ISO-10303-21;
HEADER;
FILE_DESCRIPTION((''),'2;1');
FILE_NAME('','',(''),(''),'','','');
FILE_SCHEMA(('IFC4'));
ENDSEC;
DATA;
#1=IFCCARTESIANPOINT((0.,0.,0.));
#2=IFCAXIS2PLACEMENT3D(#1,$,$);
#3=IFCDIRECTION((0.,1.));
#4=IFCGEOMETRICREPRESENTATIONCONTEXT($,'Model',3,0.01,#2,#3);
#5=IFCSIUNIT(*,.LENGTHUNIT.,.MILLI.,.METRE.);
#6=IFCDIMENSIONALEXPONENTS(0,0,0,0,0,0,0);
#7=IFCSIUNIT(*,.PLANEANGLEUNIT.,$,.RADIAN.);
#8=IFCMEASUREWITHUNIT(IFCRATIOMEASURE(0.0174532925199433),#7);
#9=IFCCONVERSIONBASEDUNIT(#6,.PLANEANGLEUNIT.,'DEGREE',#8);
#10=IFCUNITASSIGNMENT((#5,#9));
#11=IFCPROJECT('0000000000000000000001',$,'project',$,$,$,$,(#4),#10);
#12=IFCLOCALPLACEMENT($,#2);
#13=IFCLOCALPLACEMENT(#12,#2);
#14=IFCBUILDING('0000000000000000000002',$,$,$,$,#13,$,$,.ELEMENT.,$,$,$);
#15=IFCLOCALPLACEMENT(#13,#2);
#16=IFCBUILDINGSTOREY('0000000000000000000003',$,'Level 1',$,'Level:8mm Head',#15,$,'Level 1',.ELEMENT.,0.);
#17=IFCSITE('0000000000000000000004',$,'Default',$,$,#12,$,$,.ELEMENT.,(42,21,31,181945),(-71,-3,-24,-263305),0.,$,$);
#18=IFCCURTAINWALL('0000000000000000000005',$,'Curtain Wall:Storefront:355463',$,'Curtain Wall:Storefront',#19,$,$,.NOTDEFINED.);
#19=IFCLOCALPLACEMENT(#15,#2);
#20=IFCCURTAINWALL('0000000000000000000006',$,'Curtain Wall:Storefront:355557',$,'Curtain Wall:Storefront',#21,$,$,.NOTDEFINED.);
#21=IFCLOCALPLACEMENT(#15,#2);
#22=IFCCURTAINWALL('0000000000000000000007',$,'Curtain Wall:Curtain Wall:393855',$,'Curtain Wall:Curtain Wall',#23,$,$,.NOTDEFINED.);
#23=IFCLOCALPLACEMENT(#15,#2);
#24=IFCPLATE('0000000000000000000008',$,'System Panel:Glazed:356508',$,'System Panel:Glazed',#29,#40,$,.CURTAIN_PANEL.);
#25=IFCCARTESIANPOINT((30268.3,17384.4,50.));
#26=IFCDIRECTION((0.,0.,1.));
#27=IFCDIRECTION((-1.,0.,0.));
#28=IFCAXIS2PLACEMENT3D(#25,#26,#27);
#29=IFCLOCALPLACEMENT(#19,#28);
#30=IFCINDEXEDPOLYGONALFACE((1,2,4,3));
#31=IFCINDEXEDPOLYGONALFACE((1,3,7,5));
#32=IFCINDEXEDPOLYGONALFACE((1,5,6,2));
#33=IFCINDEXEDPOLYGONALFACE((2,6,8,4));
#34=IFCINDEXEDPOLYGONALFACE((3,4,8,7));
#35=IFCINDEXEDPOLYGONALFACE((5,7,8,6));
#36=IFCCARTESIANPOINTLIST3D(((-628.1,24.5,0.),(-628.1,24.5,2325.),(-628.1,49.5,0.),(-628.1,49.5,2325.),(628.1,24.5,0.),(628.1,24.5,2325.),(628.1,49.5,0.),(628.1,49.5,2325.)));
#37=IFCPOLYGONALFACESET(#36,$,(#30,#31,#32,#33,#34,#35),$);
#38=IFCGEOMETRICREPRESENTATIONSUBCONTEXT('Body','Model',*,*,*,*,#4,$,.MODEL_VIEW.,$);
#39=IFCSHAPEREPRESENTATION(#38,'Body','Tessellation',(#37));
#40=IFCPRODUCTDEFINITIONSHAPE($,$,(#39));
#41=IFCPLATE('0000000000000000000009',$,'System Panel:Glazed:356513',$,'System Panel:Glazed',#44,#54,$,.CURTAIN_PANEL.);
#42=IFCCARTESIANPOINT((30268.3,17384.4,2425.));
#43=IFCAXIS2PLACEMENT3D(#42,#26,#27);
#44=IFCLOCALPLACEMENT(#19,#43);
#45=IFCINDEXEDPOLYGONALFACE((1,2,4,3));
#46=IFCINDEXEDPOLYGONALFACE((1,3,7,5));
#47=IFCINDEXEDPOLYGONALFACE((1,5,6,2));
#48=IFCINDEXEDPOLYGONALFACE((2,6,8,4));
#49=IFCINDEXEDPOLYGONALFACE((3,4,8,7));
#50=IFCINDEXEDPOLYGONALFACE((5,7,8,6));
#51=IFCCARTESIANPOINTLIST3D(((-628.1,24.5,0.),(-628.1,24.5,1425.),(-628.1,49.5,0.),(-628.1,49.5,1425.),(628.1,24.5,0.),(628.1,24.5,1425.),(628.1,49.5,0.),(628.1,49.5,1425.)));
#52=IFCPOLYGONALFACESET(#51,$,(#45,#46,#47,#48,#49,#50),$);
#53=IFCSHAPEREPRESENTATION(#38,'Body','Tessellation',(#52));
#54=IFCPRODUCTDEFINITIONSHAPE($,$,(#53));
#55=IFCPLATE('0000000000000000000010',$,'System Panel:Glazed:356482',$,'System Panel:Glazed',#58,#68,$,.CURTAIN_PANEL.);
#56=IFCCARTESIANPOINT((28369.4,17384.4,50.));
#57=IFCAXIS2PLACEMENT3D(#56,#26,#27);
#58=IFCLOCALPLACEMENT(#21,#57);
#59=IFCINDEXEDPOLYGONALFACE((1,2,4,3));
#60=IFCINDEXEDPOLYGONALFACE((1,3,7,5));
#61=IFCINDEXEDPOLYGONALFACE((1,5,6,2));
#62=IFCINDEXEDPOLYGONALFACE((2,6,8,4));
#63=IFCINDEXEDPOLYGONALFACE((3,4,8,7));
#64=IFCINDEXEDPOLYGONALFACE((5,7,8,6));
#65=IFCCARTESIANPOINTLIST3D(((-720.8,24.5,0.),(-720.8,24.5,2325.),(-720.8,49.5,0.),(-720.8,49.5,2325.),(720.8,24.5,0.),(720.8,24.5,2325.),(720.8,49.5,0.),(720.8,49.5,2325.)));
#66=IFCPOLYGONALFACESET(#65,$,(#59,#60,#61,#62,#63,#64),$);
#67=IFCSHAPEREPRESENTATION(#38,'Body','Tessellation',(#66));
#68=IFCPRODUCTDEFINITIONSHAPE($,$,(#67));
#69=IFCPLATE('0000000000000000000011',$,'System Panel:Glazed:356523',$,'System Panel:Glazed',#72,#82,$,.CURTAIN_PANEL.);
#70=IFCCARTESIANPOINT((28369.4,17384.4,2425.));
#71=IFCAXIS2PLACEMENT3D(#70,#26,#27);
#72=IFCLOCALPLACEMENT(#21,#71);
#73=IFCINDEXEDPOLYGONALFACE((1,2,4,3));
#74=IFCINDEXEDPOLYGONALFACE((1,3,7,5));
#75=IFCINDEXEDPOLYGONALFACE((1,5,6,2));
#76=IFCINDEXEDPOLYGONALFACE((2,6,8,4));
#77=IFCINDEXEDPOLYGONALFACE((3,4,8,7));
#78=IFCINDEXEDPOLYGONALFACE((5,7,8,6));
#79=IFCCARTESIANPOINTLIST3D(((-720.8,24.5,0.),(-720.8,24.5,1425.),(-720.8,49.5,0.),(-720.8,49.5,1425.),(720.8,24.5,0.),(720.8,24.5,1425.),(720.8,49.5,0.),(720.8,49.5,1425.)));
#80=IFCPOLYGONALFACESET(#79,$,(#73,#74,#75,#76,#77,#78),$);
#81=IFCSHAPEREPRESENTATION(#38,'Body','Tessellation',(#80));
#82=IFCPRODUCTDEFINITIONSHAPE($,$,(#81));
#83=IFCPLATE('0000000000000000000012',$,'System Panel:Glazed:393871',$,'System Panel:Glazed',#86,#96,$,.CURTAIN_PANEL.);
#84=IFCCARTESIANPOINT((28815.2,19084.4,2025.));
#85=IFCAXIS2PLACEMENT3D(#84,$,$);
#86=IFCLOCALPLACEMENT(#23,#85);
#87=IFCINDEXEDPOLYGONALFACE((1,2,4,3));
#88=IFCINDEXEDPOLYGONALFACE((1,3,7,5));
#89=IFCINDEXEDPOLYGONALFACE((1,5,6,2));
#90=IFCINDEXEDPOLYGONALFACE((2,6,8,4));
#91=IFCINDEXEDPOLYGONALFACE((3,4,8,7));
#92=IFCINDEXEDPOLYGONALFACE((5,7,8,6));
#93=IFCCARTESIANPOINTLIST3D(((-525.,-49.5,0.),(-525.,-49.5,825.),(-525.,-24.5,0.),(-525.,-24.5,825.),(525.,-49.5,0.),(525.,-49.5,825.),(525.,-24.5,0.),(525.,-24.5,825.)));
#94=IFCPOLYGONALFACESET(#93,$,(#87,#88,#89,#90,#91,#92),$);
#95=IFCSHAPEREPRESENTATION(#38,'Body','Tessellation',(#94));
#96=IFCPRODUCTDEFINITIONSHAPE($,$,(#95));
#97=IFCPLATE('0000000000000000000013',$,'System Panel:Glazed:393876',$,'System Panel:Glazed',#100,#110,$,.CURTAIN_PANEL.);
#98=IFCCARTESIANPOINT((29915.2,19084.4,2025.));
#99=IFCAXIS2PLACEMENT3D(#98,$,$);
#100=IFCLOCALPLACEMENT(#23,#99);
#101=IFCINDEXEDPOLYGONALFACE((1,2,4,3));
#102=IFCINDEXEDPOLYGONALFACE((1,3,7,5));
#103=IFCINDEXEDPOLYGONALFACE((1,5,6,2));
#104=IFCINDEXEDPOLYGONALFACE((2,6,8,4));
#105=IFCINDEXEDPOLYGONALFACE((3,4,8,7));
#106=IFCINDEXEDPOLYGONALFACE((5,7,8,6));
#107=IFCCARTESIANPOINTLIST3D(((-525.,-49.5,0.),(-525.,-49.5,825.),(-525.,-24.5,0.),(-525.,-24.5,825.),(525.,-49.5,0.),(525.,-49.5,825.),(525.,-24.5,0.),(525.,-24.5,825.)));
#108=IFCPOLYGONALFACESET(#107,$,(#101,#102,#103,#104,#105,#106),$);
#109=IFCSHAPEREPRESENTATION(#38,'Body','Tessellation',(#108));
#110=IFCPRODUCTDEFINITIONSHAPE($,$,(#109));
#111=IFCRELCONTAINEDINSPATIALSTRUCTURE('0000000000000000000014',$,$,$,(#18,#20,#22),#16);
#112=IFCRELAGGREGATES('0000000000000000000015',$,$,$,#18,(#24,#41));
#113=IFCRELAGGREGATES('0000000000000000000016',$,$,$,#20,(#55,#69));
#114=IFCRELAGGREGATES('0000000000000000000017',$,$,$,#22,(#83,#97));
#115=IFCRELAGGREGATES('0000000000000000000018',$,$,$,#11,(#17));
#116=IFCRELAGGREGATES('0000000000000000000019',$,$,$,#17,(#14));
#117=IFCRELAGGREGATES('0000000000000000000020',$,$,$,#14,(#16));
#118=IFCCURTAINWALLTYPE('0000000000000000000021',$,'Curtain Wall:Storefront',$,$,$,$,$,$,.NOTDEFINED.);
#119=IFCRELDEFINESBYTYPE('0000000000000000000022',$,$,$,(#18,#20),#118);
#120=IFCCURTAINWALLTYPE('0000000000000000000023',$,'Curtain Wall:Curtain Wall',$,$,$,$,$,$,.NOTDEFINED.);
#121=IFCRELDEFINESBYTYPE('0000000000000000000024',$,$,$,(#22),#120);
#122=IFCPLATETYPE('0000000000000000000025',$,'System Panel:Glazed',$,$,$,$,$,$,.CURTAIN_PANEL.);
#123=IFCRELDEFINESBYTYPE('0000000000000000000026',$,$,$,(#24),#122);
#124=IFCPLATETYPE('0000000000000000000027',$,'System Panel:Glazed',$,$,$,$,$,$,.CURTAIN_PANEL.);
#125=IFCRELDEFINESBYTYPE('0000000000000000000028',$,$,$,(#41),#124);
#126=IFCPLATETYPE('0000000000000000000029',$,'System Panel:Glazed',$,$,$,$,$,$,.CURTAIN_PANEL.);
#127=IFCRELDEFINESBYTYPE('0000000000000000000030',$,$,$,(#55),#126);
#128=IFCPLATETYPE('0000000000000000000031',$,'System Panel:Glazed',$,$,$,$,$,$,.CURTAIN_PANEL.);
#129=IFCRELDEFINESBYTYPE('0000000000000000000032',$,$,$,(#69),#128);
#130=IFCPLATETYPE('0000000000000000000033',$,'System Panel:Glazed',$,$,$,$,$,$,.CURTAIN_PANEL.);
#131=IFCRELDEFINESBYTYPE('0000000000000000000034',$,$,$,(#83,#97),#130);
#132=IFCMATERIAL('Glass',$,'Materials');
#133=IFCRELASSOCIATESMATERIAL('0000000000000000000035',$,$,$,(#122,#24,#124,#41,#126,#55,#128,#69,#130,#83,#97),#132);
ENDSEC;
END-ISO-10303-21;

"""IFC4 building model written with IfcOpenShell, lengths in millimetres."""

from ifc_helpers import new_model, entity, si_unit, converted_unit, direction, frame, origin, place, context, subcontext, project, spatial, indexed_curve, outline, extrude, shape, source, transform, mapped, material, type_object, type_shapes, element, aggregate, save


model = new_model("IFC4")

# Units and contexts
model_context = context("Model", 3, precision=0.01, world=origin(), true_north=direction((0.0, 1.0)))
body_context = subcontext(model_context, "Body", "Model", "MODEL_VIEW")
footprint_context = subcontext(model_context, "FootPrint", "Model", "MODEL_VIEW")
ifc_project = project(units=[si_unit("LENGTHUNIT", "METRE", prefix="MILLI"), converted_unit("PLANEANGLEUNIT", "DEGREE", entity("IfcRatioMeasure", 0.0174532925199433), si_unit("PLANEANGLEUNIT", "RADIAN"), dimensions=[0, 0, 0, 0, 0, 0, 0])], contexts=[model_context])

# Site, building, storey
site_placement = place(None, origin())
site = spatial("IfcSite", under=ifc_project, at=site_placement, Name="Default", CompositionType="ELEMENT", RefLatitude=(42, 21, 31, 181945), RefLongitude=(-71, -3, -24, -263305), RefElevation=0.0)
building_placement = place(site_placement, origin())
building = spatial("IfcBuilding", under=site, at=building_placement, CompositionType="ELEMENT")
storey_placement = place(building_placement, origin())
storey = spatial("IfcBuildingStorey", under=building, at=storey_placement, Name="Level 1", ObjectType="Level:8mm Head", LongName="Level 1", CompositionType="ELEMENT", Elevation=0.0)

# Curtain wall
curtain_wall_type_1 = type_object("IfcCurtainWallType", Name="Curtain Wall:Storefront", PredefinedType="NOTDEFINED")
curtain_wall_1_placement = place(storey_placement, origin())
curtain_wall_1 = element("IfcCurtainWall", 1, at=curtain_wall_1_placement, inside=storey, type_object=curtain_wall_type_1, Name="Curtain Wall:Storefront:355463", ObjectType="Curtain Wall:Storefront", PredefinedType="NOTDEFINED")

# Curtain wall
curtain_wall_2_placement = place(storey_placement, origin())
curtain_wall_2 = element("IfcCurtainWall", 2, at=curtain_wall_2_placement, inside=storey, type_object=curtain_wall_type_1, Name="Curtain Wall:Storefront:355557", ObjectType="Curtain Wall:Storefront", PredefinedType="NOTDEFINED")

# Curtain wall
curtain_wall_type_2 = type_object("IfcCurtainWallType", Name="Curtain Wall:Curtain Wall", PredefinedType="NOTDEFINED")
curtain_wall_3_placement = place(storey_placement, origin())
curtain_wall_3 = element("IfcCurtainWall", 3, at=curtain_wall_3_placement, inside=storey, type_object=curtain_wall_type_2, Name="Curtain Wall:Curtain Wall:393855", ObjectType="Curtain Wall:Curtain Wall", PredefinedType="NOTDEFINED")

# Plates
ifc_material_1 = material(Name="Glass", Category="Materials")
plate_type_1 = type_object("IfcPlateType", Name="System Panel:Glazed", PredefinedType="CURTAIN_PANEL", material=ifc_material_1)
shared_shape_1 = source(origin(), body_context, "Body", "SweptSolid", [
    extrude(outline(indexed_curve([(-12.5, -628.1), (12.5, -628.1), (12.5, 628.1), (-12.5, 628.1), (-12.5, -628.1)], self_intersect=False)), frame((0.0, 37.0, 0.0), z_axis=(0.0, 0.0, 1.0), x_axis=(0.0, 1.0, 0.0)), (0.0, 0.0, 1.0), 2325.0),
])
shared_shape_2 = source(origin(), footprint_context, "FootPrint", "Curve2D", [
    entity("IfcIndexedPolyCurve", entity("IfcCartesianPointList2D", [[628.1, 24.5], [628.1, 49.5], [-628.1, 49.5], [-628.1, 24.5], [628.1, 24.5]]), None, False),
])
type_shapes(plate_type_1, [shared_shape_1, shared_shape_2])
plate_1_placement = place(curtain_wall_1_placement, frame((30268.3, 17384.4, 50.0), z_axis=(0.0, 0.0, 1.0), x_axis=(-1.0, 0.0, 0.0)))
plate_1 = element("IfcPlate", 4, at=plate_1_placement, type_object=plate_type_1, material=ifc_material_1, Name="System Panel:Glazed:356508", ObjectType="System Panel:Glazed", PredefinedType="CURTAIN_PANEL", shapes=[
    shape(body_context, "Body", "MappedRepresentation", [mapped(shared_shape_1, transform((0.0, 0.0, 0.0), scale=1.0))]),
    shape(body_context, "Body", "MappedRepresentation", [mapped(shared_shape_2, transform((0.0, 0.0, 0.0), scale=1.0))]),
])
plate_type_2 = type_object("IfcPlateType", Name="System Panel:Glazed", PredefinedType="CURTAIN_PANEL", material=ifc_material_1)
shared_shape_3 = source(origin(), body_context, "Body", "SweptSolid", [
    extrude(outline(indexed_curve([(-12.5, -628.1), (12.5, -628.1), (12.5, 628.1), (-12.5, 628.1), (-12.5, -628.1)], self_intersect=False)), frame((0.0, 37.0, 0.0), z_axis=(0.0, 0.0, 1.0), x_axis=(0.0, 1.0, 0.0)), (0.0, 0.0, 1.0), 1425.0),
])
shared_shape_4 = source(origin(), footprint_context, "FootPrint", "Curve2D", [
    entity("IfcIndexedPolyCurve", entity("IfcCartesianPointList2D", [[628.1, 24.5], [628.1, 49.5], [-628.1, 49.5], [-628.1, 24.5], [628.1, 24.5]]), None, False),
])
type_shapes(plate_type_2, [shared_shape_3, shared_shape_4])
plate_2_placement = place(curtain_wall_1_placement, frame((30268.3, 17384.4, 2425.0), z_axis=(0.0, 0.0, 1.0), x_axis=(-1.0, 0.0, 0.0)))
plate_2 = element("IfcPlate", 5, at=plate_2_placement, type_object=plate_type_2, material=ifc_material_1, Name="System Panel:Glazed:356513", ObjectType="System Panel:Glazed", PredefinedType="CURTAIN_PANEL", shapes=[
    shape(body_context, "Body", "MappedRepresentation", [mapped(shared_shape_3, transform((0.0, 0.0, 0.0), scale=1.0))]),
    shape(body_context, "Body", "MappedRepresentation", [mapped(shared_shape_4, transform((0.0, 0.0, 0.0), scale=1.0))]),
])
aggregate(curtain_wall_1, [plate_1, plate_2])
plate_type_3 = type_object("IfcPlateType", Name="System Panel:Glazed", PredefinedType="CURTAIN_PANEL", material=ifc_material_1)
shared_shape_5 = source(origin(), body_context, "Body", "SweptSolid", [
    extrude(outline(indexed_curve([(-12.5, -720.8), (12.5, -720.8), (12.5, 720.8), (-12.5, 720.8), (-12.5, -720.8)], self_intersect=False)), frame((0.0, 37.0, 0.0), z_axis=(0.0, 0.0, 1.0), x_axis=(0.0, 1.0, 0.0)), (0.0, 0.0, 1.0), 2325.0),
])
shared_shape_6 = source(origin(), footprint_context, "FootPrint", "Curve2D", [
    entity("IfcIndexedPolyCurve", entity("IfcCartesianPointList2D", [[720.8, 24.5], [720.8, 49.5], [-720.8, 49.5], [-720.8, 24.5], [720.8, 24.5]]), None, False),
])
type_shapes(plate_type_3, [shared_shape_5, shared_shape_6])
plate_3_placement = place(curtain_wall_2_placement, frame((28369.4, 17384.4, 50.0), z_axis=(0.0, 0.0, 1.0), x_axis=(-1.0, 0.0, 0.0)))
plate_3 = element("IfcPlate", 6, at=plate_3_placement, type_object=plate_type_3, material=ifc_material_1, Name="System Panel:Glazed:356482", ObjectType="System Panel:Glazed", PredefinedType="CURTAIN_PANEL", shapes=[
    shape(body_context, "Body", "MappedRepresentation", [mapped(shared_shape_5, transform((0.0, 0.0, 0.0), scale=1.0))]),
    shape(body_context, "Body", "MappedRepresentation", [mapped(shared_shape_6, transform((0.0, 0.0, 0.0), scale=1.0))]),
])
plate_type_4 = type_object("IfcPlateType", Name="System Panel:Glazed", PredefinedType="CURTAIN_PANEL", material=ifc_material_1)
shared_shape_7 = source(origin(), body_context, "Body", "SweptSolid", [
    extrude(outline(indexed_curve([(-12.5, -720.8), (12.5, -720.8), (12.5, 720.8), (-12.5, 720.8), (-12.5, -720.8)], self_intersect=False)), frame((0.0, 37.0, 0.0), z_axis=(0.0, 0.0, 1.0), x_axis=(0.0, 1.0, 0.0)), (0.0, 0.0, 1.0), 1425.0),
])
shared_shape_8 = source(origin(), footprint_context, "FootPrint", "Curve2D", [
    entity("IfcIndexedPolyCurve", entity("IfcCartesianPointList2D", [[720.8, 24.5], [720.8, 49.5], [-720.8, 49.5], [-720.8, 24.5], [720.8, 24.5]]), None, False),
])
type_shapes(plate_type_4, [shared_shape_7, shared_shape_8])
plate_4_placement = place(curtain_wall_2_placement, frame((28369.4, 17384.4, 2425.0), z_axis=(0.0, 0.0, 1.0), x_axis=(-1.0, 0.0, 0.0)))
plate_4 = element("IfcPlate", 7, at=plate_4_placement, type_object=plate_type_4, material=ifc_material_1, Name="System Panel:Glazed:356523", ObjectType="System Panel:Glazed", PredefinedType="CURTAIN_PANEL", shapes=[
    shape(body_context, "Body", "MappedRepresentation", [mapped(shared_shape_7, transform((0.0, 0.0, 0.0), scale=1.0))]),
    shape(body_context, "Body", "MappedRepresentation", [mapped(shared_shape_8, transform((0.0, 0.0, 0.0), scale=1.0))]),
])
aggregate(curtain_wall_2, [plate_3, plate_4])
plate_type_5 = type_object("IfcPlateType", Name="System Panel:Glazed", PredefinedType="CURTAIN_PANEL", material=ifc_material_1)
shared_shape_9 = source(origin(), body_context, "Body", "SweptSolid", [
    extrude(outline(indexed_curve([(-12.5, -525.0), (12.5, -525.0), (12.5, 525.0), (-12.5, 525.0), (-12.5, -525.0)], self_intersect=False)), frame((0.0, -37.0, 0.0), z_axis=(0.0, 0.0, 1.0), x_axis=(0.0, 1.0, 0.0)), (0.0, 0.0, 1.0), 825.0),
])
shared_shape_10 = source(origin(), footprint_context, "FootPrint", "Curve2D", [
    entity("IfcIndexedPolyCurve", entity("IfcCartesianPointList2D", [[525.0, -49.5], [525.0, -24.5], [-525.0, -24.5], [-525.0, -49.5], [525.0, -49.5]]), None, False),
])
type_shapes(plate_type_5, [shared_shape_9, shared_shape_10])
plate_5_placement = place(curtain_wall_3_placement, frame((28815.2, 19084.4, 2025.0)))
plate_5 = element("IfcPlate", 8, at=plate_5_placement, type_object=plate_type_5, material=ifc_material_1, Name="System Panel:Glazed:393871", ObjectType="System Panel:Glazed", PredefinedType="CURTAIN_PANEL", shapes=[
    shape(body_context, "Body", "MappedRepresentation", [mapped(shared_shape_9, transform((0.0, 0.0, 0.0), scale=1.0))]),
    shape(body_context, "Body", "MappedRepresentation", [mapped(shared_shape_10, transform((0.0, 0.0, 0.0), scale=1.0))]),
])
plate_6_placement = place(curtain_wall_3_placement, frame((29915.2, 19084.4, 2025.0)))
plate_6 = element("IfcPlate", 9, at=plate_6_placement, type_object=plate_type_5, material=ifc_material_1, Name="System Panel:Glazed:393876", ObjectType="System Panel:Glazed", PredefinedType="CURTAIN_PANEL", shapes=[
    shape(body_context, "Body", "MappedRepresentation", [mapped(shared_shape_9, transform((0.0, 0.0, 0.0), scale=1.0))]),
    shape(body_context, "Body", "MappedRepresentation", [mapped(shared_shape_10, transform((0.0, 0.0, 0.0), scale=1.0))]),
])

aggregate(curtain_wall_3, [plate_5, plate_6])

save(model, "model.ifc")
